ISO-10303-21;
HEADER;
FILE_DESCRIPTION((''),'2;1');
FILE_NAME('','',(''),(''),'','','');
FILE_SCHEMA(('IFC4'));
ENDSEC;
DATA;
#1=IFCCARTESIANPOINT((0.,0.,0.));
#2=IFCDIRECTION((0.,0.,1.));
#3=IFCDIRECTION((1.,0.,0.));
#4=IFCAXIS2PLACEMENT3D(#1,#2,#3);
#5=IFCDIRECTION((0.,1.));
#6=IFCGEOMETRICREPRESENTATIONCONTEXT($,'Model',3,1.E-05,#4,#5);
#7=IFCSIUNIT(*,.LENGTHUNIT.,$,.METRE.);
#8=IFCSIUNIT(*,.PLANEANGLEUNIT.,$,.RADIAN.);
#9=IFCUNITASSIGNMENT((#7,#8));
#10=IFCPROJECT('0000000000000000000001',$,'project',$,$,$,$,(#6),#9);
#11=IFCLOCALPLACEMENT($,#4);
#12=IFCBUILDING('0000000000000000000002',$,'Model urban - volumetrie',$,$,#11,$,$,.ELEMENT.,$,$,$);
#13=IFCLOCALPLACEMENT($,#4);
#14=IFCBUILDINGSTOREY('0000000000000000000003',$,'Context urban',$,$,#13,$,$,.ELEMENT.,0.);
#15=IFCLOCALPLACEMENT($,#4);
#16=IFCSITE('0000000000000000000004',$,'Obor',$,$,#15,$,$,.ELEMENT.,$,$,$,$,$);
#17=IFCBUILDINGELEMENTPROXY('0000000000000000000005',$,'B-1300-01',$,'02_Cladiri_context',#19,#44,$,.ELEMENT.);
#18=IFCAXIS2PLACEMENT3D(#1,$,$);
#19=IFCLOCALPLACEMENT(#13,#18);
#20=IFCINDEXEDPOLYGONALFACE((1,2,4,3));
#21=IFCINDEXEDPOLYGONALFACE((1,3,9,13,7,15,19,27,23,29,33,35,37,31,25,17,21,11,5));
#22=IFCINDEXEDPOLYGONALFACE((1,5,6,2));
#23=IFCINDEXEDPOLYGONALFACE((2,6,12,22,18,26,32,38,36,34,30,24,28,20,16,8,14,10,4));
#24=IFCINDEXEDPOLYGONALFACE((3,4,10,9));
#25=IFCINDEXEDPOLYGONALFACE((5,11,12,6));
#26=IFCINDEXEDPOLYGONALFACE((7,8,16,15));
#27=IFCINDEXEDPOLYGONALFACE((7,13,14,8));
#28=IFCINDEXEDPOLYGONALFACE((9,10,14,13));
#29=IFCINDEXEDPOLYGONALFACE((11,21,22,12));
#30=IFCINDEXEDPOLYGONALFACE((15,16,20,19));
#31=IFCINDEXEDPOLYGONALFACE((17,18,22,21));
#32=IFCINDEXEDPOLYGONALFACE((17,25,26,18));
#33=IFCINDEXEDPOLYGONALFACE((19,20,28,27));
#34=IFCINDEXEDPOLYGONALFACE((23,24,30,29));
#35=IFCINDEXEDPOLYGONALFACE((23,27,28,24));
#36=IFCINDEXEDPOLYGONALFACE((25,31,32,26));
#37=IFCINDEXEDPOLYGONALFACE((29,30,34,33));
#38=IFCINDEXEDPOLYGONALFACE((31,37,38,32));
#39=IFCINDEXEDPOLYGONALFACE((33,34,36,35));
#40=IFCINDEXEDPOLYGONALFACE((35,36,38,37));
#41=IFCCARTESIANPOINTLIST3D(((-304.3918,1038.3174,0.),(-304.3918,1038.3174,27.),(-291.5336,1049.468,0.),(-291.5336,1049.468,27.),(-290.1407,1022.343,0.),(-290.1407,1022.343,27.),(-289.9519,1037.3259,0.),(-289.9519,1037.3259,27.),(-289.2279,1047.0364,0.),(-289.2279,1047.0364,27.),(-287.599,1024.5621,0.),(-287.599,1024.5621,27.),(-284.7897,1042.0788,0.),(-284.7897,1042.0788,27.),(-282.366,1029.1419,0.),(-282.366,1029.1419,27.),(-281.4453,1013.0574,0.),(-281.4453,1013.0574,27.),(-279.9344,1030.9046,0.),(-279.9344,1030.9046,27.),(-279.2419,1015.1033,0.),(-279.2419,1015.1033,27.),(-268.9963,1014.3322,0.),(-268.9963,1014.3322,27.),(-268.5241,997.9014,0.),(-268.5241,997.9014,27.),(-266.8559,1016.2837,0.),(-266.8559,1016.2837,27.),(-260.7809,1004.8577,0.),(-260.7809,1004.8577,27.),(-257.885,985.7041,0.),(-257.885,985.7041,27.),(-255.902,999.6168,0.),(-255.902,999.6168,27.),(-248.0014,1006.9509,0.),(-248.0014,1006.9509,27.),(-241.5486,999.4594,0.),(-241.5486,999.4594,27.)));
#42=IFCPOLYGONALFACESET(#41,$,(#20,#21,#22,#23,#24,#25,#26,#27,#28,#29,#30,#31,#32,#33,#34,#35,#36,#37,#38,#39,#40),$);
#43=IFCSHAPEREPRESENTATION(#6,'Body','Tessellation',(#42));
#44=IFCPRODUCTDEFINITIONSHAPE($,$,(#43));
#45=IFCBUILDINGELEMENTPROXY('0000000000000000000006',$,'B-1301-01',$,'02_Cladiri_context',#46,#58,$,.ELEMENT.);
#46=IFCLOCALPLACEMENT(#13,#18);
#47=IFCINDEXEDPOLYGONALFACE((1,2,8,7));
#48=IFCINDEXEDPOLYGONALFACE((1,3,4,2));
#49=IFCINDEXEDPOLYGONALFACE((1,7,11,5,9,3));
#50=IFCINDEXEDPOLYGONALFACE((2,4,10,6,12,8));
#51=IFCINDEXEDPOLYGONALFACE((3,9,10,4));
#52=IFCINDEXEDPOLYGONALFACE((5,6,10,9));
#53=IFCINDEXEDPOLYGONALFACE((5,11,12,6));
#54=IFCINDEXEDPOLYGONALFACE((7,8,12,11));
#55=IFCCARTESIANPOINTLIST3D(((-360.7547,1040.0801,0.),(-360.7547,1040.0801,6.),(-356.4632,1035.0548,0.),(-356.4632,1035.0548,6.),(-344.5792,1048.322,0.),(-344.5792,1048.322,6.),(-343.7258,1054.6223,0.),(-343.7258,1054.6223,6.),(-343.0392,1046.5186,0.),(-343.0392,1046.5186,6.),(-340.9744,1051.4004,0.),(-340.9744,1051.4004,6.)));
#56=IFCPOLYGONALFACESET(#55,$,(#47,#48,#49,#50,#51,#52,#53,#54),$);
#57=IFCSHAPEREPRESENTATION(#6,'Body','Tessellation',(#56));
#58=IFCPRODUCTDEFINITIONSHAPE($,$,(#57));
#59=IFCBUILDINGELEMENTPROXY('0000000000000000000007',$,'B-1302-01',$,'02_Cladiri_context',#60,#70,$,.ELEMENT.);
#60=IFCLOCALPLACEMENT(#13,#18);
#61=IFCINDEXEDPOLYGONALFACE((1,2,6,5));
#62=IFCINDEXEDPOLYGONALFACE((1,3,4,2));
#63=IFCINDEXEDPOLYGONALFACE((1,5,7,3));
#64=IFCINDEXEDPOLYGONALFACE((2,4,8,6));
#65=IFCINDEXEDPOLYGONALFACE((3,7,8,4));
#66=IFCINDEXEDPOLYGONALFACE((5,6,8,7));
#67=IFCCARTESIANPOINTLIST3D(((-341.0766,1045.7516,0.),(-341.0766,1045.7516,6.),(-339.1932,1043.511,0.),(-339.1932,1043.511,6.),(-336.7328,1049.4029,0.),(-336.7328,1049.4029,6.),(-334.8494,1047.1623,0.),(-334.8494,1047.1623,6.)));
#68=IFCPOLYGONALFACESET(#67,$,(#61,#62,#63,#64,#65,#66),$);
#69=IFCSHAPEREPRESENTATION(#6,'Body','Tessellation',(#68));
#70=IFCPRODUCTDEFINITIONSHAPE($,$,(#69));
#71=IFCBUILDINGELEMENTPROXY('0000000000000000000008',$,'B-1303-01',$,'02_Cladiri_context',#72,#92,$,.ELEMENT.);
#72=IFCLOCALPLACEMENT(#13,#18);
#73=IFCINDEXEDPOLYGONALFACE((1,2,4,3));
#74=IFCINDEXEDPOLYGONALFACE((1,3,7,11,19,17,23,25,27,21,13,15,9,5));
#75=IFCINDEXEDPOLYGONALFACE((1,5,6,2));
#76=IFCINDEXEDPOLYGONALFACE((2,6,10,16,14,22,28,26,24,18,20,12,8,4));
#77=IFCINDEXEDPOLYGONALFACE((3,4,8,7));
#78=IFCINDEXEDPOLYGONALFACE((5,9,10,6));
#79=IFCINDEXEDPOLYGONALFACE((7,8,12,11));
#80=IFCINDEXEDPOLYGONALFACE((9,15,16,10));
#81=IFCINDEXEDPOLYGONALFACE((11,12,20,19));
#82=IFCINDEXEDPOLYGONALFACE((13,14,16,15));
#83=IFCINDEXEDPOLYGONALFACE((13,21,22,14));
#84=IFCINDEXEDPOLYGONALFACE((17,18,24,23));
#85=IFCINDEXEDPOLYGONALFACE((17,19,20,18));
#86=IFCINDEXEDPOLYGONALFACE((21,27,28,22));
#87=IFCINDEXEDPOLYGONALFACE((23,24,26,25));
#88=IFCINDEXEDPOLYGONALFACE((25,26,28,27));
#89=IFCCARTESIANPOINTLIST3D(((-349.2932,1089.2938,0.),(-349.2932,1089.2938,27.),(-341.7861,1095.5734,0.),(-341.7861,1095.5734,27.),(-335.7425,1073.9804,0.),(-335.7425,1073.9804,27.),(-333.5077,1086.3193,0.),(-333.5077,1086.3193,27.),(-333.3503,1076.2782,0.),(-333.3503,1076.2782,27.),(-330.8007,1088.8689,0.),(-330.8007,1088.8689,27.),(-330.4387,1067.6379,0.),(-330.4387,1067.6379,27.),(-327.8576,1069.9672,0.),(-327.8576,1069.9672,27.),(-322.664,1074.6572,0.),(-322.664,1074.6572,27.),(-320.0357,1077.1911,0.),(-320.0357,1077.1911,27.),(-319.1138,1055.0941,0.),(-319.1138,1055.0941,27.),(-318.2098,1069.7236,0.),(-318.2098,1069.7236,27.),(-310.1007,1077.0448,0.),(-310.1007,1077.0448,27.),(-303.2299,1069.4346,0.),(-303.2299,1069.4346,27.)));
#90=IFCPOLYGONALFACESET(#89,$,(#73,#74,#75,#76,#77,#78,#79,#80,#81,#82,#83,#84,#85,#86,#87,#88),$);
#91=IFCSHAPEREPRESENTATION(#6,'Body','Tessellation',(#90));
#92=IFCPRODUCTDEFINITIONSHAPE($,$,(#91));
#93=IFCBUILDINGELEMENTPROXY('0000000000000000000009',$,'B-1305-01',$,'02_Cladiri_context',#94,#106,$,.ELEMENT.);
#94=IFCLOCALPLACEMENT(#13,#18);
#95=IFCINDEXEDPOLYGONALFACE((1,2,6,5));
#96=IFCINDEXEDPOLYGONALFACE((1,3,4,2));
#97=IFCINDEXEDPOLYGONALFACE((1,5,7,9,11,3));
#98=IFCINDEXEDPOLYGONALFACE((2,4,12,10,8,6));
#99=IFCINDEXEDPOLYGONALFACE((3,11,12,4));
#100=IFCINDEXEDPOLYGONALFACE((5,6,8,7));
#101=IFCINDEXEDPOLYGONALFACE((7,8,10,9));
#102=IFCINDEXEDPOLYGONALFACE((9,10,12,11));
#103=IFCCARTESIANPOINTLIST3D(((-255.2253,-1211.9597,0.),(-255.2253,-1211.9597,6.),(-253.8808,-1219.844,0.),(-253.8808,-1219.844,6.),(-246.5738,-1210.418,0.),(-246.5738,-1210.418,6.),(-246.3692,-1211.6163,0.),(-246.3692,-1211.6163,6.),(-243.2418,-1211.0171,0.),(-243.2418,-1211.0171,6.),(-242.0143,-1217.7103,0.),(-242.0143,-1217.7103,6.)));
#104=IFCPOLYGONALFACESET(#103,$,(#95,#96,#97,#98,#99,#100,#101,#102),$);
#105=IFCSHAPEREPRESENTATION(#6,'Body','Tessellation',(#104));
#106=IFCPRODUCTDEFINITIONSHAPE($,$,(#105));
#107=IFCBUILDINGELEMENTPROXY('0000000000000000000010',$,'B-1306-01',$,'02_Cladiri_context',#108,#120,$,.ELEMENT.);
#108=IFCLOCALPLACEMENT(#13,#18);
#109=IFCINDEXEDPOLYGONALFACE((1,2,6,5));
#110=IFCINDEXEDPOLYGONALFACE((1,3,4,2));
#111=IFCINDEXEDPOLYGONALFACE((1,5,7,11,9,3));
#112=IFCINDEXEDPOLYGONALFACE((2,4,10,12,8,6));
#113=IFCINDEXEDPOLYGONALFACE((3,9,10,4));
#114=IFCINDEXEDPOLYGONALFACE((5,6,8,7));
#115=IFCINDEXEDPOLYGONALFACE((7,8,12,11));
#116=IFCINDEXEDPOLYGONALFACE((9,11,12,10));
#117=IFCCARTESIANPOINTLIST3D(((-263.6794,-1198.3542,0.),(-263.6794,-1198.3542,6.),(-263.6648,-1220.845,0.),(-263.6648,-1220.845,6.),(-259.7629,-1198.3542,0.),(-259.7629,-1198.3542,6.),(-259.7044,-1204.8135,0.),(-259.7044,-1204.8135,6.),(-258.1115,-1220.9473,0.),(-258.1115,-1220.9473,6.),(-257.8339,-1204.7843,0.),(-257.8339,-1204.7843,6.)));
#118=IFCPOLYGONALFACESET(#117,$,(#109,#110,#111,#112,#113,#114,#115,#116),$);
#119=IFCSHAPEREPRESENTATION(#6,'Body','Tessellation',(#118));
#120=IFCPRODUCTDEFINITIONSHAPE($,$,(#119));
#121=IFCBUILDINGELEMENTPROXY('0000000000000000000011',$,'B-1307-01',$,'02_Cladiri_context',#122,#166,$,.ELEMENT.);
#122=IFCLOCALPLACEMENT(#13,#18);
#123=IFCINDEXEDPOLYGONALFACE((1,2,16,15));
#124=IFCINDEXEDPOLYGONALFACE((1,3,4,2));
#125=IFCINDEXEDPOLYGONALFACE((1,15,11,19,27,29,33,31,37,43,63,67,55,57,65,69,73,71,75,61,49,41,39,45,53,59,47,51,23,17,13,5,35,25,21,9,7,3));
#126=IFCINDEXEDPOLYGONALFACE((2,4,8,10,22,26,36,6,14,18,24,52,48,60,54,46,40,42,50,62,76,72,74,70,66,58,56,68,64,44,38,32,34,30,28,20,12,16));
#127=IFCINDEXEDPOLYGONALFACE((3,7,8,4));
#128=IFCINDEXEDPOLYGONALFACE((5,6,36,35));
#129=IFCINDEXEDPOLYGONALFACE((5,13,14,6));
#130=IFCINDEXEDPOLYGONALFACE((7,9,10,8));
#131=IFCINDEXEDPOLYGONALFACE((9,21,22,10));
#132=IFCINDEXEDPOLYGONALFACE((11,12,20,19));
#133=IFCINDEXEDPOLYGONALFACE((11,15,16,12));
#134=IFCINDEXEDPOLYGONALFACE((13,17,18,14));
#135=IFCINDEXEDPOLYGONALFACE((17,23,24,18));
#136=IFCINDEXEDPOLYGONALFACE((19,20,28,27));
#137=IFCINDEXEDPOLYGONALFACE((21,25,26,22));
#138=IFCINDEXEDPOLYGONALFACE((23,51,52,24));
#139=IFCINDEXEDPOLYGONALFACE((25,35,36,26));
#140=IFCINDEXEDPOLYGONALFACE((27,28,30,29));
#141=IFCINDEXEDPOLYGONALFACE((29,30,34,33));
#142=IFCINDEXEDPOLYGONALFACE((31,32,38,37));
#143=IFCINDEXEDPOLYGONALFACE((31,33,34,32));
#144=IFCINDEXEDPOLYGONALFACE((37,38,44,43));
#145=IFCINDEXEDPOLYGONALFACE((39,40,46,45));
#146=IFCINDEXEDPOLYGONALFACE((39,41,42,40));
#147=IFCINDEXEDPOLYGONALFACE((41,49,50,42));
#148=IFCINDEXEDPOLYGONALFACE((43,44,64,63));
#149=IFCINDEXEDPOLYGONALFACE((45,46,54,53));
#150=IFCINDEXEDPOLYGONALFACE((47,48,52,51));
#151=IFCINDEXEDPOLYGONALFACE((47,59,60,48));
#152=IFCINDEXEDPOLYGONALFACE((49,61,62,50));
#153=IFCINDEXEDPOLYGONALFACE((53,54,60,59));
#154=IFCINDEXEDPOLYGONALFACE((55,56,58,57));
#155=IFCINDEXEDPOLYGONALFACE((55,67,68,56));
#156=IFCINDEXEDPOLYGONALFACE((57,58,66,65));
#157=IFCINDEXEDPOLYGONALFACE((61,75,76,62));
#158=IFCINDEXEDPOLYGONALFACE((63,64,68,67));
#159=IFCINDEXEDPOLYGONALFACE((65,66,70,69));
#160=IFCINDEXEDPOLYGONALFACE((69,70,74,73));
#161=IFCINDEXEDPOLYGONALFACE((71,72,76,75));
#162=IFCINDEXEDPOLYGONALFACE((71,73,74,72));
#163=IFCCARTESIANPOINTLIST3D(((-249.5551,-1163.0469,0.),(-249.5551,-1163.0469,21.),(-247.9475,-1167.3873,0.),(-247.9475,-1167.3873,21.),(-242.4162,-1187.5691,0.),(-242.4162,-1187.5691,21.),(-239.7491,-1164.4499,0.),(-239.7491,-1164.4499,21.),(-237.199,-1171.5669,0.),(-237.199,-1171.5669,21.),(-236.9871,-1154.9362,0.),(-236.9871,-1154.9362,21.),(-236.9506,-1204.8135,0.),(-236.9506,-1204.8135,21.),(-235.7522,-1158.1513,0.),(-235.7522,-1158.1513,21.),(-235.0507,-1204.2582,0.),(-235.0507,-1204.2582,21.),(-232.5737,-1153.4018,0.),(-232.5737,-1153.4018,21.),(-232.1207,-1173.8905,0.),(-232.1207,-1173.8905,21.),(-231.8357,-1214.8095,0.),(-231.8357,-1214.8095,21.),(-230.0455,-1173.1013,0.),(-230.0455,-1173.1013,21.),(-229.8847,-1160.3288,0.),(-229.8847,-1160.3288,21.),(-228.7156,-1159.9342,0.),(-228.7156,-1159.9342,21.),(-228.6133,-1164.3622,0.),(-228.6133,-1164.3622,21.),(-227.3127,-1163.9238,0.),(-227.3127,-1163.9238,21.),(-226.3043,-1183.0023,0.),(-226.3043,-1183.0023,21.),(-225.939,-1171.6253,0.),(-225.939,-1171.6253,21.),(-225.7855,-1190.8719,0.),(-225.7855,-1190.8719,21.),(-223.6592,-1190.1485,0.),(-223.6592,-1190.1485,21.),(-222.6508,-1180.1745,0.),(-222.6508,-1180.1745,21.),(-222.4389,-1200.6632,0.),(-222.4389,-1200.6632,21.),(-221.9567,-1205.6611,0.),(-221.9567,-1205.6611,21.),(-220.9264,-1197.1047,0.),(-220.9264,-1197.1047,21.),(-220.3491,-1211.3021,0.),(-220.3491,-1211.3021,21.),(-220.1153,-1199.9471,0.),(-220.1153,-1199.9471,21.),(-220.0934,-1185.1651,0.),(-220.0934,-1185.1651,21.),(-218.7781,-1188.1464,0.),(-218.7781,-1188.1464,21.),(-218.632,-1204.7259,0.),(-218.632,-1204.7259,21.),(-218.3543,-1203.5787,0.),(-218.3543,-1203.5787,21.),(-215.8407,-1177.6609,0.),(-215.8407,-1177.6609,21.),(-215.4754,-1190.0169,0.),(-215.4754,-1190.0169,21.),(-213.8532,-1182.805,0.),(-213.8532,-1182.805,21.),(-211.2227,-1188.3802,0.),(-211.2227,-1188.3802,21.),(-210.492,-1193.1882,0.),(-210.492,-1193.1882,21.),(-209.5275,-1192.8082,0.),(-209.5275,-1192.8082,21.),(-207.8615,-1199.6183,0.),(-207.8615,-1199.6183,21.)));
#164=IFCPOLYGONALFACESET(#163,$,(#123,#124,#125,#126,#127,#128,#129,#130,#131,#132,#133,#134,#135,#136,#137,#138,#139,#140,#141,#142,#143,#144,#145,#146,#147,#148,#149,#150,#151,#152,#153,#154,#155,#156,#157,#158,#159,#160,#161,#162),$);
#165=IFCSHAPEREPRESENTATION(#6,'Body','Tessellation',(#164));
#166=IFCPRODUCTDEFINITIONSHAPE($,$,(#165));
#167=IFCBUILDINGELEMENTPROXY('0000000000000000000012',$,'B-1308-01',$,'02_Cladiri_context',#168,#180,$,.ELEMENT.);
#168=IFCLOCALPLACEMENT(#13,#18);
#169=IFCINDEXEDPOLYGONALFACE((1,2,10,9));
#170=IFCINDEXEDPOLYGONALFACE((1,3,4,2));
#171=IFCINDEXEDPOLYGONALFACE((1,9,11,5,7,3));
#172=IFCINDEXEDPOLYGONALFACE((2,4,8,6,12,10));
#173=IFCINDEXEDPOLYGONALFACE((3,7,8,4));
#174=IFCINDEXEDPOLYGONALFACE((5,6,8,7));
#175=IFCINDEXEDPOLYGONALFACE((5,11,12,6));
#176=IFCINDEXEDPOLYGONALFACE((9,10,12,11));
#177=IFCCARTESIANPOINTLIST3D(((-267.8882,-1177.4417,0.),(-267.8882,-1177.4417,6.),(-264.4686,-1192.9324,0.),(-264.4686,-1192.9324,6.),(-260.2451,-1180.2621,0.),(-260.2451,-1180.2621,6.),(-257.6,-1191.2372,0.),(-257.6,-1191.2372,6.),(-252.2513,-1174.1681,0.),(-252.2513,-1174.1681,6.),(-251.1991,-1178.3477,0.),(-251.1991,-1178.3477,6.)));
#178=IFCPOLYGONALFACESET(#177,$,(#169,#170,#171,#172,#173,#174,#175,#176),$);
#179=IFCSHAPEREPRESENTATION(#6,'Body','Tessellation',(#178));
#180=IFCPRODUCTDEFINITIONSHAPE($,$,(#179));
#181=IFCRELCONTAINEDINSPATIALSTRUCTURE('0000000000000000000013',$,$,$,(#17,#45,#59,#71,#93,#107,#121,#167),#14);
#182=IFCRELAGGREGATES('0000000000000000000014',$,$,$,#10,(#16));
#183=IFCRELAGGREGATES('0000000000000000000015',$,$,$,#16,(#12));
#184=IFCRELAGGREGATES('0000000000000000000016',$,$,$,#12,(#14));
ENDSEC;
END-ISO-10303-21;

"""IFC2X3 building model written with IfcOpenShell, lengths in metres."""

from ifc_helpers import new_model, si_unit, direction, origin_with_axes, place, context, project, spatial, polyline, outline, extrude, element, save


model = new_model("IFC2X3")

# Units and contexts
model_context = context("Model", 3, precision=1e-05, world=origin_with_axes(), true_north=direction((0.0, 1.0)))
ifc_project = project(units=[si_unit("LENGTHUNIT", "METRE"), si_unit("PLANEANGLEUNIT", "RADIAN")], contexts=[model_context])

# Site, building, storey
site_placement = place(None, origin_with_axes())
site = spatial("IfcSite", under=ifc_project, at=site_placement, Name="Obor", CompositionType="ELEMENT")
building_placement = place(None, origin_with_axes())
building = spatial("IfcBuilding", under=site, at=building_placement, Name="Model urban - volumetrie", CompositionType="ELEMENT")
storey_placement = place(None, origin_with_axes())
storey = spatial("IfcBuildingStorey", under=building, at=storey_placement, Name="Context urban", CompositionType="ELEMENT", Elevation=0.0)

# Building element proxies
proxy_1_placement = place(None, origin_with_axes())
element("IfcBuildingElementProxy", 1, at=proxy_1_placement, inside=storey, Name="B-1300-01", ObjectType="02_Cladiri_context", CompositionType="ELEMENT", context=model_context, shape_type="SweptSolid", body=[
    extrude(outline(polyline([(-268.9963, 1014.3322), (-266.8559, 1016.2837), (-279.9344, 1030.9046), (-282.366, 1029.1419), (-289.9519, 1037.3259), (-284.7897, 1042.0788), (-289.2279, 1047.0364), (-291.5336, 1049.468), (-304.3918, 1038.3174), (-290.1407, 1022.343), (-287.599, 1024.5621), (-279.2419, 1015.1033), (-281.4453, 1013.0574), (-268.5241, 997.9014), (-257.885, 985.7041), (-241.5486, 999.4594), (-248.0014, 1006.9509), (-255.902, 999.6168), (-260.7809, 1004.8577), (-268.9963, 1014.3322)])), origin_with_axes(), (0.0, 0.0, 1.0), 27.0),
])
proxy_2_placement = place(None, origin_with_axes())
element("IfcBuildingElementProxy", 2, at=proxy_2_placement, inside=storey, Name="B-1301-01", ObjectType="02_Cladiri_context", CompositionType="ELEMENT", context=model_context, shape_type="SweptSolid", body=[
    extrude(outline(polyline([(-340.9744, 1051.4004), (-343.7258, 1054.6223), (-360.7547, 1040.0801), (-356.4632, 1035.0548), (-343.0392, 1046.5186), (-344.5792, 1048.322), (-340.9744, 1051.4004)])), origin_with_axes(), (0.0, 0.0, 1.0), 6.0),
])
proxy_3_placement = place(None, origin_with_axes())
element("IfcBuildingElementProxy", 3, at=proxy_3_placement, inside=storey, Name="B-1302-01", ObjectType="02_Cladiri_context", CompositionType="ELEMENT", context=model_context, shape_type="SweptSolid", body=[
    extrude(outline(polyline([(-334.8494, 1047.1623), (-336.7328, 1049.4029), (-341.0766, 1045.7516), (-339.1932, 1043.511), (-334.8494, 1047.1623)])), origin_with_axes(), (0.0, 0.0, 1.0), 6.0),
])
proxy_4_placement = place(None, origin_with_axes())
element("IfcBuildingElementProxy", 4, at=proxy_4_placement, inside=storey, Name="B-1303-01", ObjectType="02_Cladiri_context", CompositionType="ELEMENT", context=model_context, shape_type="SweptSolid", body=[
    extrude(outline(polyline([(-320.0357, 1077.1911), (-330.8007, 1088.8689), (-333.5077, 1086.3193), (-341.7861, 1095.5734), (-349.2932, 1089.2938), (-335.7425, 1073.9804), (-333.3503, 1076.2782), (-327.8576, 1069.9672), (-330.4387, 1067.6379), (-319.1138, 1055.0941), (-303.2299, 1069.4346), (-310.1007, 1077.0448), (-318.2098, 1069.7236), (-322.664, 1074.6572), (-320.0357, 1077.1911)])), origin_with_axes(), (0.0, 0.0, 1.0), 27.0),
])
proxy_5_placement = place(None, origin_with_axes())
element("IfcBuildingElementProxy", 5, at=proxy_5_placement, inside=storey, Name="B-1305-01", ObjectType="02_Cladiri_context", CompositionType="ELEMENT", context=model_context, shape_type="SweptSolid", body=[
    extrude(outline(polyline([(-246.3692, -1211.6163), (-246.5738, -1210.418), (-255.2253, -1211.9597), (-253.8808, -1219.844), (-242.0143, -1217.7103), (-243.2418, -1211.0171), (-246.3692, -1211.6163)])), origin_with_axes(), (0.0, 0.0, 1.0), 6.0),
])
proxy_6_placement = place(None, origin_with_axes())
element("IfcBuildingElementProxy", 6, at=proxy_6_placement, inside=storey, Name="B-1306-01", ObjectType="02_Cladiri_context", CompositionType="ELEMENT", context=model_context, shape_type="SweptSolid", body=[
    extrude(outline(polyline([(-259.7629, -1198.3542), (-263.6794, -1198.3542), (-263.6648, -1220.845), (-258.1115, -1220.9473), (-257.8339, -1204.7843), (-259.7044, -1204.8135), (-259.7629, -1198.3542)])), origin_with_axes(), (0.0, 0.0, 1.0), 6.0),
])
proxy_7_placement = place(None, origin_with_axes())
element("IfcBuildingElementProxy", 7, at=proxy_7_placement, inside=storey, Name="B-1307-01", ObjectType="02_Cladiri_context", CompositionType="ELEMENT", context=model_context, shape_type="SweptSolid", body=[
    extrude(outline(polyline([(-239.7491, -1164.4499), (-237.199, -1171.5669), (-232.1207, -1173.8905), (-230.0455, -1173.1013), (-226.3043, -1183.0023), (-242.4162, -1187.5691), (-236.9506, -1204.8135), (-235.0507, -1204.2582), (-231.8357, -1214.8095), (-220.3491, -1211.3021), (-221.9567, -1205.6611), (-218.632, -1204.7259), (-220.1153, -1199.9471), (-222.4389, -1200.6632), (-225.7855, -1190.8719), (-223.6592, -1190.1485), (-220.9264, -1197.1047), (-218.3543, -1203.5787), (-207.8615, -1199.6183), (-210.492, -1193.1882), (-209.5275, -1192.8082), (-211.2227, -1188.3802), (-215.4754, -1190.0169), (-218.7781, -1188.1464), (-220.0934, -1185.1651), (-213.8532, -1182.805), (-215.8407, -1177.6609), (-222.6508, -1180.1745), (-225.939, -1171.6253), (-228.6133, -1164.3622), (-227.3127, -1163.9238), (-228.7156, -1159.9342), (-229.8847, -1160.3288), (-232.5737, -1153.4018), (-236.9871, -1154.9362), (-235.7522, -1158.1513), (-249.5551, -1163.0469), (-247.9475, -1167.3873), (-239.7491, -1164.4499)])), origin_with_axes(), (0.0, 0.0, 1.0), 21.0),
])
proxy_8_placement = place(None, origin_with_axes())
element("IfcBuildingElementProxy", 8, at=proxy_8_placement, inside=storey, Name="B-1308-01", ObjectType="02_Cladiri_context", CompositionType="ELEMENT", context=model_context, shape_type="SweptSolid", body=[
    extrude(outline(polyline([(-257.6, -1191.2372), (-260.2451, -1180.2621), (-251.1991, -1178.3477), (-252.2513, -1174.1681), (-267.8882, -1177.4417), (-264.4686, -1192.9324), (-257.6, -1191.2372)])), origin_with_axes(), (0.0, 0.0, 1.0), 6.0),
])

save(model, "model.ifc")
